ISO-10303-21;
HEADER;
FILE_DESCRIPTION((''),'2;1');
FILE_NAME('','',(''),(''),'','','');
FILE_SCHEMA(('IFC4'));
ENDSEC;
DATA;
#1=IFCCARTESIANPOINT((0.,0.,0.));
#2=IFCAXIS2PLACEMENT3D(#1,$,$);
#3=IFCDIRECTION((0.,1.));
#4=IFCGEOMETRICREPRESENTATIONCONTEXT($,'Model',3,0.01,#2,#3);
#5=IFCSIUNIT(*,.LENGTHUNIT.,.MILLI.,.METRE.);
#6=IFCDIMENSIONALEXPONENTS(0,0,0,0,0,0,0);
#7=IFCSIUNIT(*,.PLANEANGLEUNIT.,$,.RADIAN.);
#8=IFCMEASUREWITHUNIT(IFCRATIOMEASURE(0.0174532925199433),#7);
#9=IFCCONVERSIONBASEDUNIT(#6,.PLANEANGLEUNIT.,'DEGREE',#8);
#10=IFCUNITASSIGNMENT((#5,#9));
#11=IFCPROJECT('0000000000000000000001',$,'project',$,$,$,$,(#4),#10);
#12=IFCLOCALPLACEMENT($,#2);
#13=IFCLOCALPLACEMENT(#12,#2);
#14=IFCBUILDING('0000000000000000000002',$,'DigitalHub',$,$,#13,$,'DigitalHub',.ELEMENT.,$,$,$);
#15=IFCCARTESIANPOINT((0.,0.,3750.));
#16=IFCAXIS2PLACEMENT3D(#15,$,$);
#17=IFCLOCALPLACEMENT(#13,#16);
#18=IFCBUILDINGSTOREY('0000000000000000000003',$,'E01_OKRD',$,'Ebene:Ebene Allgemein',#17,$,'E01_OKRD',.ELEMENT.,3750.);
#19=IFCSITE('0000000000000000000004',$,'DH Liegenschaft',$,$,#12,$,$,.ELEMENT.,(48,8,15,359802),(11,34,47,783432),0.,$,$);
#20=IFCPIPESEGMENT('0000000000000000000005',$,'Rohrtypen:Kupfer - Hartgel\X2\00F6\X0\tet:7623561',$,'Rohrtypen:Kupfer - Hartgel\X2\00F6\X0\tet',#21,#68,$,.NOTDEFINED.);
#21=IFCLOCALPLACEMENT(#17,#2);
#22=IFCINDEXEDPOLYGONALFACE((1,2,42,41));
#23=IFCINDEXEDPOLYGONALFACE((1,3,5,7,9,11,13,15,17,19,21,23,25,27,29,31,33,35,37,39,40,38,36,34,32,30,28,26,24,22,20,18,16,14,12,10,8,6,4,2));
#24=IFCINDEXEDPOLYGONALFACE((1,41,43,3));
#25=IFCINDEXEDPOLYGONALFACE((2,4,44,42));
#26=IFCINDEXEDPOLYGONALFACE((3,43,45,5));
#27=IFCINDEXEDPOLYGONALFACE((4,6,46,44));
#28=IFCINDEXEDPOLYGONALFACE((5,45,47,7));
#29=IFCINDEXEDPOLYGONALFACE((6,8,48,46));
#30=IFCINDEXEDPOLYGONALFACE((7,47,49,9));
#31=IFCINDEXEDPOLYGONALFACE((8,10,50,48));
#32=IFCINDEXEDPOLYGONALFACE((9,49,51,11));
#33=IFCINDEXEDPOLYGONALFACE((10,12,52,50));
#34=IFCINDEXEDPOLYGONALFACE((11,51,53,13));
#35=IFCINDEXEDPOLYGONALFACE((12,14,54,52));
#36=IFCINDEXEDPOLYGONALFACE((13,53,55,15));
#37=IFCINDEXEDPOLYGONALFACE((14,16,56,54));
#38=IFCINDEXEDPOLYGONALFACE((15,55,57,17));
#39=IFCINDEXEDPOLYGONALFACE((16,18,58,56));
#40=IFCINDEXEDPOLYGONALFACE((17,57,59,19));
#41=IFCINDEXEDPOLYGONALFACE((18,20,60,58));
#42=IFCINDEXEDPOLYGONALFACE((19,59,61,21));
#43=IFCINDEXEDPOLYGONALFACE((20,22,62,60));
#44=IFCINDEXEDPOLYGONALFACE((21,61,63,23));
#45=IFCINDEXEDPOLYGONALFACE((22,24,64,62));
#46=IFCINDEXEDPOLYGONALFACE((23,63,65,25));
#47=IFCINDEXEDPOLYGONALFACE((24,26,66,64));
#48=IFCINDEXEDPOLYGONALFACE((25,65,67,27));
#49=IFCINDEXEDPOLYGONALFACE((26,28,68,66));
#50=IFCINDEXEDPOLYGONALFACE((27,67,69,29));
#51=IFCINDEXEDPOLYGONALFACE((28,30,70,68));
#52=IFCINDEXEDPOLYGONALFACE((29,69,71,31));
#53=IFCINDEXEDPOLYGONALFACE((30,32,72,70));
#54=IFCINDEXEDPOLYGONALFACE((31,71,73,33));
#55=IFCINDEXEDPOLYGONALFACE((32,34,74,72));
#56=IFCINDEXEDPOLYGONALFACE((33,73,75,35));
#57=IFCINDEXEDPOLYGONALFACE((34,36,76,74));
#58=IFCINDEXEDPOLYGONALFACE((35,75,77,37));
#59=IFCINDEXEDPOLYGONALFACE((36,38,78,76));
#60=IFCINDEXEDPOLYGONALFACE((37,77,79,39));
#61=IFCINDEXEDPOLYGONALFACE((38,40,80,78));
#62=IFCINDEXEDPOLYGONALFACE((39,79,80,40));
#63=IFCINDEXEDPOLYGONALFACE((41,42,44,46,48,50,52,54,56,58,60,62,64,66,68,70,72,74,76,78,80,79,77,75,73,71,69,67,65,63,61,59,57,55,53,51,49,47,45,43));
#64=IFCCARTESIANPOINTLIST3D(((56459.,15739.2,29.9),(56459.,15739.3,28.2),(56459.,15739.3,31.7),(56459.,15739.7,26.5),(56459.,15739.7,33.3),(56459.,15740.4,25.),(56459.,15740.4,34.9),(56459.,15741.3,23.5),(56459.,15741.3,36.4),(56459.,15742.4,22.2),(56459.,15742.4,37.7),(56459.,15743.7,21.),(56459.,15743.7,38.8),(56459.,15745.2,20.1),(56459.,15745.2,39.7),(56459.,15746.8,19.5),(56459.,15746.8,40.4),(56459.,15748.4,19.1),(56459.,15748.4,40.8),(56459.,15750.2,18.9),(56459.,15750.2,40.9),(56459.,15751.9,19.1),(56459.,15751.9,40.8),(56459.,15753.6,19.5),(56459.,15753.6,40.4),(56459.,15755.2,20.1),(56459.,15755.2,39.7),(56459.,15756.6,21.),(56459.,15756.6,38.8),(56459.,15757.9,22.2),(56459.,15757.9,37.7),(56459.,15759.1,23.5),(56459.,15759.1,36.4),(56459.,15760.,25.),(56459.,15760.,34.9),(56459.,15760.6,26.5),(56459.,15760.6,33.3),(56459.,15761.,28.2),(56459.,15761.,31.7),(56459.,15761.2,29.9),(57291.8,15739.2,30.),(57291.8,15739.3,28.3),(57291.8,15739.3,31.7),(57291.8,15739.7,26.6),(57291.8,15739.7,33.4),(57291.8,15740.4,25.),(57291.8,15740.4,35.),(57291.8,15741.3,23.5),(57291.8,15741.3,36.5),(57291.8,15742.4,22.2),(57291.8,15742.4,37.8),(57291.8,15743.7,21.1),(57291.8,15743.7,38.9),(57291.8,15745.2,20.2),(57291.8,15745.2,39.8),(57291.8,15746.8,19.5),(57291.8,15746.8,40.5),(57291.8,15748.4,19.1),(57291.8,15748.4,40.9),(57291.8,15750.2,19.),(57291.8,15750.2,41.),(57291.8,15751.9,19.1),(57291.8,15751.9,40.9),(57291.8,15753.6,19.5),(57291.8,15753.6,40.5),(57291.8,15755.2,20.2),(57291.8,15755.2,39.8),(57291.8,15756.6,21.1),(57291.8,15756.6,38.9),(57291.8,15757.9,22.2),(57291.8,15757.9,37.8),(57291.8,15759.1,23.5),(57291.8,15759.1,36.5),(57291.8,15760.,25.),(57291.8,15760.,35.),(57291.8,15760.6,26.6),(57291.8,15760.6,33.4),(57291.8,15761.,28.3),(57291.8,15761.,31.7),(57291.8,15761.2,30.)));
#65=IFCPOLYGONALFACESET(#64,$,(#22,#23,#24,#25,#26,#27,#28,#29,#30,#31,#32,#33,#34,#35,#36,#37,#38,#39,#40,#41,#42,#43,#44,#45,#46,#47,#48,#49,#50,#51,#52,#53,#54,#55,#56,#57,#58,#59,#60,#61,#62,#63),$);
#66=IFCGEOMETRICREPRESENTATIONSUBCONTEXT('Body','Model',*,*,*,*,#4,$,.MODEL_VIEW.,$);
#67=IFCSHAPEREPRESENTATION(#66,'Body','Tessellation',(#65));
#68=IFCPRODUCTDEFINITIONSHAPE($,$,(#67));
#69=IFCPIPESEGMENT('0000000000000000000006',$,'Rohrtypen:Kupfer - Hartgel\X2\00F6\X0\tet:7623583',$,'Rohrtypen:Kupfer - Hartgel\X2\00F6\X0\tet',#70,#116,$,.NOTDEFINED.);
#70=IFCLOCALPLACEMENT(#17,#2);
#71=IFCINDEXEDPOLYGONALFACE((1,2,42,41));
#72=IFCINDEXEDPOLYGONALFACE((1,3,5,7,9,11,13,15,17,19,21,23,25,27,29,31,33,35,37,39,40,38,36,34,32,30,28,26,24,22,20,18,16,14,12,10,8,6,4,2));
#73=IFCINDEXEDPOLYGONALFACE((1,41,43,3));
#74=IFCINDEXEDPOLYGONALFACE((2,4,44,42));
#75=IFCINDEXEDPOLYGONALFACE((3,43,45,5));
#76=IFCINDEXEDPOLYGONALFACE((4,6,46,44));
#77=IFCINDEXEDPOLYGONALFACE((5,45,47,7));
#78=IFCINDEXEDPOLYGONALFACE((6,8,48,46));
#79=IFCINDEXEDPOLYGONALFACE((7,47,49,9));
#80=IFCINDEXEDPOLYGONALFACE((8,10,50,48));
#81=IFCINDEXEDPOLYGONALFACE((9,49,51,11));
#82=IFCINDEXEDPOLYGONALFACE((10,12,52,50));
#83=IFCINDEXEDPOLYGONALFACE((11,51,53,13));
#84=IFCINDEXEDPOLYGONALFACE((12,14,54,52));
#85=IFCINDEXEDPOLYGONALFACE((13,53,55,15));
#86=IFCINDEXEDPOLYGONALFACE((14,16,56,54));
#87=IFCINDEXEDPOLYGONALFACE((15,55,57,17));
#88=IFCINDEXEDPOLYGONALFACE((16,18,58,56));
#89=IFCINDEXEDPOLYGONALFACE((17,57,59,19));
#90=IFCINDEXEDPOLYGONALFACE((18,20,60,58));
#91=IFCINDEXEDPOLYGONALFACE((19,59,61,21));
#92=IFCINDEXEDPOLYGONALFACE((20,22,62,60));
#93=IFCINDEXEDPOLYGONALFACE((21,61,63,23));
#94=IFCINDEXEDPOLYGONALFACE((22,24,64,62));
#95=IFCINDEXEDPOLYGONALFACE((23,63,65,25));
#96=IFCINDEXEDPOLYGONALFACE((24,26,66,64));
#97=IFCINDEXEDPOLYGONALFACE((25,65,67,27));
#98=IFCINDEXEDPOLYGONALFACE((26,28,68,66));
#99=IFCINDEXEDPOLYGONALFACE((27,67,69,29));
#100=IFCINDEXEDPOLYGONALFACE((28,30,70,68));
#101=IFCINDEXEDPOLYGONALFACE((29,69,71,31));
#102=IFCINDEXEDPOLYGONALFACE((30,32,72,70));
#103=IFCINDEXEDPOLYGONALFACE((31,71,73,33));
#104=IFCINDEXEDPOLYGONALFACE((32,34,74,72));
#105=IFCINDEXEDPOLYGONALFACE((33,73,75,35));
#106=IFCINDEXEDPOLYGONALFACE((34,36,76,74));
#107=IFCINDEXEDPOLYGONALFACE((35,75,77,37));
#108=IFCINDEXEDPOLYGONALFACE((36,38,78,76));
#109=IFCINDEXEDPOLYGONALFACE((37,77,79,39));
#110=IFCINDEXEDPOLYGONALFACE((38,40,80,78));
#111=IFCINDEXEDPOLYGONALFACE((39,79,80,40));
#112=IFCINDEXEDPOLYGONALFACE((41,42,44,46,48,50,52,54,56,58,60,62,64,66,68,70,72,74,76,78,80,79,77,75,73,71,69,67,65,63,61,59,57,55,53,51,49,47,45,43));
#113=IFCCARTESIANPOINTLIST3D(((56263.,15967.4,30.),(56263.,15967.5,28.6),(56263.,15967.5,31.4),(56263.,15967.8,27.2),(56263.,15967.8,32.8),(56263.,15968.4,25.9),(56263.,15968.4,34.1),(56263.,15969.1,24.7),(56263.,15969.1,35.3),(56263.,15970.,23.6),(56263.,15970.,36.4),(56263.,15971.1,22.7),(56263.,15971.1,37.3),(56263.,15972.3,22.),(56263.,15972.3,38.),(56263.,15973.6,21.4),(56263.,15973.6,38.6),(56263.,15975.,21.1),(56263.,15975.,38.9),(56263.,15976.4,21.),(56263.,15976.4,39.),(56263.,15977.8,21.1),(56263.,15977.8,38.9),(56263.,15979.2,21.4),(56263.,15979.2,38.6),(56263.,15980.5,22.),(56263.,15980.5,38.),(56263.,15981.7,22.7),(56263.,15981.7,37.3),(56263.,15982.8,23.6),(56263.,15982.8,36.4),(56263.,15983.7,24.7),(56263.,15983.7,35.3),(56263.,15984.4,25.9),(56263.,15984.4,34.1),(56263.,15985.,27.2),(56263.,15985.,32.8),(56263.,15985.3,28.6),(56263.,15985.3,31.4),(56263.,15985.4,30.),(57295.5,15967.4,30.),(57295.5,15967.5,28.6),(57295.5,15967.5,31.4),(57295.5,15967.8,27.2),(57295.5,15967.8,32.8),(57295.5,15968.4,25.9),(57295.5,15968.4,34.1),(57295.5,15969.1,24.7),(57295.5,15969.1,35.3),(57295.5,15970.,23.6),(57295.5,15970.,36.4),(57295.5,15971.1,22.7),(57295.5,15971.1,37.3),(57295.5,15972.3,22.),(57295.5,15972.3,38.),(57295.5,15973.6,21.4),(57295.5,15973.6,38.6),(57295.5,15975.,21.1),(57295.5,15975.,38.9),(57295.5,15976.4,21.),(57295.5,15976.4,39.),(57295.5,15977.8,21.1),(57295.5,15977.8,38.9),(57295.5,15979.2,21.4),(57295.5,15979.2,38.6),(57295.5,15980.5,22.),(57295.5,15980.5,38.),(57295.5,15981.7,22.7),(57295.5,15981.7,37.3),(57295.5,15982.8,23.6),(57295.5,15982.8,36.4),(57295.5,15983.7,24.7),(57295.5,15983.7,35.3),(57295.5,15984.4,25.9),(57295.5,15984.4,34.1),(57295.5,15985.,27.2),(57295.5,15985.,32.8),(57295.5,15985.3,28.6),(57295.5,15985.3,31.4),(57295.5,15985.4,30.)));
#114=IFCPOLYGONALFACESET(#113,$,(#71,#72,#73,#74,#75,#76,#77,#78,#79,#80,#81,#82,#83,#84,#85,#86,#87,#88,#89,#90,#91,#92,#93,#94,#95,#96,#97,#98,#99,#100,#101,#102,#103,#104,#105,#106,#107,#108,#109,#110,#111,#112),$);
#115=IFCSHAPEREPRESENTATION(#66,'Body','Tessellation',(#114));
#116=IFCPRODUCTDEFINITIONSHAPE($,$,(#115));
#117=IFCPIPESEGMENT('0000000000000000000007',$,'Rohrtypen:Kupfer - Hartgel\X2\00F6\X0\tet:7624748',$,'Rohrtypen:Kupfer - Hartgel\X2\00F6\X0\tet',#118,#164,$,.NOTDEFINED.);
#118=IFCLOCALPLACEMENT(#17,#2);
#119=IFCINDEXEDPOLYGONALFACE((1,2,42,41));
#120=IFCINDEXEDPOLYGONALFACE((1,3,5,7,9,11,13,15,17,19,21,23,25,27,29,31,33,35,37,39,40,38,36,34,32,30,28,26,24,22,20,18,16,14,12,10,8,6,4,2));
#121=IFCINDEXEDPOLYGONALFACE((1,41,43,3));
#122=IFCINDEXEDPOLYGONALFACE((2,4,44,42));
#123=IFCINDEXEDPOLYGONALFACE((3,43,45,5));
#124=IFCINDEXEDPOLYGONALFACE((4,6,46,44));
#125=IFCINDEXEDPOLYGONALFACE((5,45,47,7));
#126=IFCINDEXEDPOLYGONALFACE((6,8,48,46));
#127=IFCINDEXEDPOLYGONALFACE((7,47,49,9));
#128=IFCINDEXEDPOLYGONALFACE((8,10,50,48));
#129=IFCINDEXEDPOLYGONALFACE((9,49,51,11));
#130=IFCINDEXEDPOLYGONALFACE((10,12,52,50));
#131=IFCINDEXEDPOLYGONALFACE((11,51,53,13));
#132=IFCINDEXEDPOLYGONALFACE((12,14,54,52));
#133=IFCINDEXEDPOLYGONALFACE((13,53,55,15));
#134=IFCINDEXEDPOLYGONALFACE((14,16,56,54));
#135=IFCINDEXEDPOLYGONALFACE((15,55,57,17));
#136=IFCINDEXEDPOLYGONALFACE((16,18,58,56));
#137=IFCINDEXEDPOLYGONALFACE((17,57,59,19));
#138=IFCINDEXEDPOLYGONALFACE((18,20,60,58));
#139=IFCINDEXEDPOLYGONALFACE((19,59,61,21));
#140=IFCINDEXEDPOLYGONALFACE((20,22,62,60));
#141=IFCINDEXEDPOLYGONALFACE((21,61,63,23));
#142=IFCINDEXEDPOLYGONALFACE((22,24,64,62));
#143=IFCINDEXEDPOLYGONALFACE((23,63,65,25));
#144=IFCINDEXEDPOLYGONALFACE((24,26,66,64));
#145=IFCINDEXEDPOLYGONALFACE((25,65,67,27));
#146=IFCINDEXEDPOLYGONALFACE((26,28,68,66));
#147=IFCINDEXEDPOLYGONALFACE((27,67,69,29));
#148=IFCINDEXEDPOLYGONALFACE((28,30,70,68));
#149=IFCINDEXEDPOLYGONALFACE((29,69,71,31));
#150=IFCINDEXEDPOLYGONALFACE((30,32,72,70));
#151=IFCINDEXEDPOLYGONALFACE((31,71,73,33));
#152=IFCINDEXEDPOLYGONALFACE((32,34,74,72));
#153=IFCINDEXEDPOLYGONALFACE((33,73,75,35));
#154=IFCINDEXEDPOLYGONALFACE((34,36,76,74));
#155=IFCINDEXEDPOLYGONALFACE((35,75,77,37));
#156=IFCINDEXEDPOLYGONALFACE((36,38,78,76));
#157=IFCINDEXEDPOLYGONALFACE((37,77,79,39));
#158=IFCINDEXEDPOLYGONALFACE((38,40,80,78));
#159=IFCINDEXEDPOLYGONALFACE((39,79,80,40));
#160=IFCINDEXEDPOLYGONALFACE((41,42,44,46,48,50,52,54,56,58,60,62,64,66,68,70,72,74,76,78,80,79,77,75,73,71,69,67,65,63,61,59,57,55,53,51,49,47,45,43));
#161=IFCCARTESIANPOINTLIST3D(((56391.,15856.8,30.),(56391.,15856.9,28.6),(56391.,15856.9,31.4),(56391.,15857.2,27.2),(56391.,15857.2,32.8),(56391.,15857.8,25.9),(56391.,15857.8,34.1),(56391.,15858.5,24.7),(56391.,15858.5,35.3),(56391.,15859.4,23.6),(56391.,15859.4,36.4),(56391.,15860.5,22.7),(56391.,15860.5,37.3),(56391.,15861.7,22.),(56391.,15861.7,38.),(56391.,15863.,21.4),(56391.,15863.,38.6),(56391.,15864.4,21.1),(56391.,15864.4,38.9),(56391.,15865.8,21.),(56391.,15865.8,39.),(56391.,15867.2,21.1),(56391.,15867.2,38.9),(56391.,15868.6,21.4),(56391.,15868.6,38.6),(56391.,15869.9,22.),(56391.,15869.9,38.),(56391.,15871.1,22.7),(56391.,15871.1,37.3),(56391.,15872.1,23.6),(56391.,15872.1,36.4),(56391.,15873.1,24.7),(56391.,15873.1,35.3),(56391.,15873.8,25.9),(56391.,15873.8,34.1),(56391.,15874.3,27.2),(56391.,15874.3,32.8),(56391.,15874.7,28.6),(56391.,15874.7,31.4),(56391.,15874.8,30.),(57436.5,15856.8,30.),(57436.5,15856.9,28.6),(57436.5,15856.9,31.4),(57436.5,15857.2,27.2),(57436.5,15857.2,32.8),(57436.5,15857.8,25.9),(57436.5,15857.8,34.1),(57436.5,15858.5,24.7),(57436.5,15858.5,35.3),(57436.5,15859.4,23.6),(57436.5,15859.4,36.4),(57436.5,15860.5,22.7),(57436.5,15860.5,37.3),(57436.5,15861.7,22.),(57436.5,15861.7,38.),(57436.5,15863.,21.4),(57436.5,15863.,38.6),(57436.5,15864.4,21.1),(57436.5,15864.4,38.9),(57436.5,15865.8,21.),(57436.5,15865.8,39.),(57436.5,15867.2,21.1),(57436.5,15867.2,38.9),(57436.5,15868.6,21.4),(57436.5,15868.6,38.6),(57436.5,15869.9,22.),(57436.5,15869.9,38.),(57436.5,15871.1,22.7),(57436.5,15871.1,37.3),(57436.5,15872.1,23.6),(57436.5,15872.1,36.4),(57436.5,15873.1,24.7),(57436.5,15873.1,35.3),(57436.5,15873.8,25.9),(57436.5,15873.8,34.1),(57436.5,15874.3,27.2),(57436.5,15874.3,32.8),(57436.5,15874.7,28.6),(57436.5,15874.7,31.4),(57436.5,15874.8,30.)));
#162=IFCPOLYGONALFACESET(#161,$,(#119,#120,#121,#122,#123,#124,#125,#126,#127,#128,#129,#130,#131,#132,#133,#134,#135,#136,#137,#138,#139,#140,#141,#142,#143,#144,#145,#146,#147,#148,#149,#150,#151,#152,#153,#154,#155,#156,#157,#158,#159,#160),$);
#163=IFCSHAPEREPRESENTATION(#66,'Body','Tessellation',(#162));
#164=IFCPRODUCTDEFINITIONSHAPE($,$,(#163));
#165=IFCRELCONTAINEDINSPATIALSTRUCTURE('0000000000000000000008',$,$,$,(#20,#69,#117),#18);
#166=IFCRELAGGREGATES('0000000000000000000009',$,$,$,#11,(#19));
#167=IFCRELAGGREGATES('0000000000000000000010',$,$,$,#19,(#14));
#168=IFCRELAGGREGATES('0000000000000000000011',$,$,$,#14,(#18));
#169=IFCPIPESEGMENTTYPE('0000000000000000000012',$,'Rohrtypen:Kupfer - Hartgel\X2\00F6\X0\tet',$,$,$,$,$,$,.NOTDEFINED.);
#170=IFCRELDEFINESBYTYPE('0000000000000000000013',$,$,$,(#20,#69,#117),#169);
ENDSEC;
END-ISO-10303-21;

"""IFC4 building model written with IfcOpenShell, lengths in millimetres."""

from ifc_helpers import new_model, entity, si_unit, converted_unit, direction, frame, origin, place, context, subcontext, project, spatial, indexed_curve, outline, extrude, type_object, element, save


model = new_model("IFC4")

# Units and contexts
model_context = context("Model", 3, precision=0.01, world=origin(), true_north=direction((0.0, 1.0)))
body_context = subcontext(model_context, "Body", "Model", "MODEL_VIEW")
ifc_project = project(units=[si_unit("LENGTHUNIT", "METRE", prefix="MILLI"), converted_unit("PLANEANGLEUNIT", "DEGREE", entity("IfcRatioMeasure", 0.0174532925199433), si_unit("PLANEANGLEUNIT", "RADIAN"), dimensions=[0, 0, 0, 0, 0, 0, 0])], contexts=[model_context])

# Site, building, storey
site_placement = place(None, origin())
site = spatial("IfcSite", under=ifc_project, at=site_placement, Name="DH Liegenschaft", CompositionType="ELEMENT", RefLatitude=(48, 8, 15, 359802), RefLongitude=(11, 34, 47, 783432), RefElevation=0.0)
building_placement = place(site_placement, origin())
building = spatial("IfcBuilding", under=site, at=building_placement, Name="DigitalHub", LongName="DigitalHub", CompositionType="ELEMENT")
storey_placement = place(building_placement, frame((0.0, 0.0, 3750.0)))
storey = spatial("IfcBuildingStorey", under=building, at=storey_placement, Name="E01_OKRD", ObjectType="Ebene:Ebene Allgemein", LongName="E01_OKRD", CompositionType="ELEMENT", Elevation=3750.0)

# Pipe segments
pipe_segment_type = type_object("IfcPipeSegmentType", Name="Rohrtypen:Kupfer - Hartgelötet", PredefinedType="NOTDEFINED")
pipe_segment_1_placement = place(storey_placement, frame((56459.0, 15737.6, 17.4)))
element("IfcPipeSegment", 1, at=pipe_segment_1_placement, inside=storey, type_object=pipe_segment_type, Name="Rohrtypen:Kupfer - Hartgelötet:7623561", ObjectType="Rohrtypen:Kupfer - Hartgelötet", PredefinedType="NOTDEFINED", context=body_context, shape_type="SweptSolid", body=[
    extrude(outline(indexed_curve([(11.0, 0.0), (10.9, 1.7), (10.5, 3.4), (9.8, 5.0), (8.9, 6.5), (7.8, 7.8), (6.5, 8.9), (5.0, 9.8), (3.4, 10.5), (1.7, 10.9), (0.0, 11.0), (-1.7, 10.9), (-3.4, 10.5), (-5.0, 9.8), (-6.5, 8.9), (-7.8, 7.8), (-8.9, 6.5), (-9.8, 5.0), (-10.5, 3.4), (-10.9, 1.7), (-11.0, 0.0), (-10.9, -1.7), (-10.5, -3.4), (-9.8, -5.0), (-8.9, -6.5), (-7.8, -7.8), (-6.5, -8.9), (-5.0, -9.8), (-3.4, -10.5), (-1.7, -10.9), (0.0, -11.0), (1.7, -10.9), (3.4, -10.5), (5.0, -9.8), (6.5, -8.9), (7.8, -7.8), (8.9, -6.5), (9.8, -5.0), (10.5, -3.4), (10.9, -1.7), (11.0, 0.0)], self_intersect=False)), frame((0.0, 12.6, 12.6), z_axis=(1.0, 0.0, 0.000052), x_axis=(0.0, 1.0, 0.0)), (0.0, 0.0, 1.0), 832.9),
])
pipe_segment_2_placement = place(storey_placement, frame((56263.0, 15965.8, 19.4)))
element("IfcPipeSegment", 2, at=pipe_segment_2_placement, inside=storey, type_object=pipe_segment_type, Name="Rohrtypen:Kupfer - Hartgelötet:7623583", ObjectType="Rohrtypen:Kupfer - Hartgelötet", PredefinedType="NOTDEFINED", context=body_context, shape_type="SweptSolid", body=[
    extrude(outline(indexed_curve([(9.0, 0.0), (8.9, 1.4), (8.6, 2.8), (8.0, 4.1), (7.3, 5.3), (6.4, 6.4), (5.3, 7.3), (4.1, 8.0), (2.8, 8.6), (1.4, 8.9), (0.0, 9.0), (-1.4, 8.9), (-2.8, 8.6), (-4.1, 8.0), (-5.3, 7.3), (-6.4, 6.4), (-7.3, 5.3), (-8.0, 4.1), (-8.6, 2.8), (-8.9, 1.4), (-9.0, 0.0), (-8.9, -1.4), (-8.6, -2.8), (-8.0, -4.1), (-7.3, -5.3), (-6.4, -6.4), (-5.3, -7.3), (-4.1, -8.0), (-2.8, -8.6), (-1.4, -8.9), (0.0, -9.0), (1.4, -8.9), (2.8, -8.6), (4.1, -8.0), (5.3, -7.3), (6.4, -6.4), (7.3, -5.3), (8.0, -4.1), (8.6, -2.8), (8.9, -1.4), (9.0, 0.0)], self_intersect=False)), frame((0.0, 10.6, 10.6), z_axis=(1.0, 0.0, 0.0), x_axis=(0.0, 1.0, 0.0)), (0.0, 0.0, 1.0), 1032.6),
])
pipe_segment_3_placement = place(storey_placement, frame((56391.0, 15855.2, 19.4)))
element("IfcPipeSegment", 3, at=pipe_segment_3_placement, inside=storey, type_object=pipe_segment_type, Name="Rohrtypen:Kupfer - Hartgelötet:7624748", ObjectType="Rohrtypen:Kupfer - Hartgelötet", PredefinedType="NOTDEFINED", context=body_context, shape_type="SweptSolid", body=[
    extrude(outline(indexed_curve([(9.0, 0.0), (8.9, 1.4), (8.6, 2.8), (8.0, 4.1), (7.3, 5.3), (6.4, 6.4), (5.3, 7.3), (4.1, 8.0), (2.8, 8.6), (1.4, 8.9), (0.0, 9.0), (-1.4, 8.9), (-2.8, 8.6), (-4.1, 8.0), (-5.3, 7.3), (-6.4, 6.4), (-7.3, 5.3), (-8.0, 4.1), (-8.6, 2.8), (-8.9, 1.4), (-9.0, 0.0), (-8.9, -1.4), (-8.6, -2.8), (-8.0, -4.1), (-7.3, -5.3), (-6.4, -6.4), (-5.3, -7.3), (-4.1, -8.0), (-2.8, -8.6), (-1.4, -8.9), (0.0, -9.0), (1.4, -8.9), (2.8, -8.6), (4.1, -8.0), (5.3, -7.3), (6.4, -6.4), (7.3, -5.3), (8.0, -4.1), (8.6, -2.8), (8.9, -1.4), (9.0, 0.0)], self_intersect=False)), frame((0.0, 10.6, 10.6), z_axis=(1.0, 0.0, 0.0), x_axis=(0.0, 1.0, 0.0)), (0.0, 0.0, 1.0), 1045.6),
])

save(model, "model.ifc")
